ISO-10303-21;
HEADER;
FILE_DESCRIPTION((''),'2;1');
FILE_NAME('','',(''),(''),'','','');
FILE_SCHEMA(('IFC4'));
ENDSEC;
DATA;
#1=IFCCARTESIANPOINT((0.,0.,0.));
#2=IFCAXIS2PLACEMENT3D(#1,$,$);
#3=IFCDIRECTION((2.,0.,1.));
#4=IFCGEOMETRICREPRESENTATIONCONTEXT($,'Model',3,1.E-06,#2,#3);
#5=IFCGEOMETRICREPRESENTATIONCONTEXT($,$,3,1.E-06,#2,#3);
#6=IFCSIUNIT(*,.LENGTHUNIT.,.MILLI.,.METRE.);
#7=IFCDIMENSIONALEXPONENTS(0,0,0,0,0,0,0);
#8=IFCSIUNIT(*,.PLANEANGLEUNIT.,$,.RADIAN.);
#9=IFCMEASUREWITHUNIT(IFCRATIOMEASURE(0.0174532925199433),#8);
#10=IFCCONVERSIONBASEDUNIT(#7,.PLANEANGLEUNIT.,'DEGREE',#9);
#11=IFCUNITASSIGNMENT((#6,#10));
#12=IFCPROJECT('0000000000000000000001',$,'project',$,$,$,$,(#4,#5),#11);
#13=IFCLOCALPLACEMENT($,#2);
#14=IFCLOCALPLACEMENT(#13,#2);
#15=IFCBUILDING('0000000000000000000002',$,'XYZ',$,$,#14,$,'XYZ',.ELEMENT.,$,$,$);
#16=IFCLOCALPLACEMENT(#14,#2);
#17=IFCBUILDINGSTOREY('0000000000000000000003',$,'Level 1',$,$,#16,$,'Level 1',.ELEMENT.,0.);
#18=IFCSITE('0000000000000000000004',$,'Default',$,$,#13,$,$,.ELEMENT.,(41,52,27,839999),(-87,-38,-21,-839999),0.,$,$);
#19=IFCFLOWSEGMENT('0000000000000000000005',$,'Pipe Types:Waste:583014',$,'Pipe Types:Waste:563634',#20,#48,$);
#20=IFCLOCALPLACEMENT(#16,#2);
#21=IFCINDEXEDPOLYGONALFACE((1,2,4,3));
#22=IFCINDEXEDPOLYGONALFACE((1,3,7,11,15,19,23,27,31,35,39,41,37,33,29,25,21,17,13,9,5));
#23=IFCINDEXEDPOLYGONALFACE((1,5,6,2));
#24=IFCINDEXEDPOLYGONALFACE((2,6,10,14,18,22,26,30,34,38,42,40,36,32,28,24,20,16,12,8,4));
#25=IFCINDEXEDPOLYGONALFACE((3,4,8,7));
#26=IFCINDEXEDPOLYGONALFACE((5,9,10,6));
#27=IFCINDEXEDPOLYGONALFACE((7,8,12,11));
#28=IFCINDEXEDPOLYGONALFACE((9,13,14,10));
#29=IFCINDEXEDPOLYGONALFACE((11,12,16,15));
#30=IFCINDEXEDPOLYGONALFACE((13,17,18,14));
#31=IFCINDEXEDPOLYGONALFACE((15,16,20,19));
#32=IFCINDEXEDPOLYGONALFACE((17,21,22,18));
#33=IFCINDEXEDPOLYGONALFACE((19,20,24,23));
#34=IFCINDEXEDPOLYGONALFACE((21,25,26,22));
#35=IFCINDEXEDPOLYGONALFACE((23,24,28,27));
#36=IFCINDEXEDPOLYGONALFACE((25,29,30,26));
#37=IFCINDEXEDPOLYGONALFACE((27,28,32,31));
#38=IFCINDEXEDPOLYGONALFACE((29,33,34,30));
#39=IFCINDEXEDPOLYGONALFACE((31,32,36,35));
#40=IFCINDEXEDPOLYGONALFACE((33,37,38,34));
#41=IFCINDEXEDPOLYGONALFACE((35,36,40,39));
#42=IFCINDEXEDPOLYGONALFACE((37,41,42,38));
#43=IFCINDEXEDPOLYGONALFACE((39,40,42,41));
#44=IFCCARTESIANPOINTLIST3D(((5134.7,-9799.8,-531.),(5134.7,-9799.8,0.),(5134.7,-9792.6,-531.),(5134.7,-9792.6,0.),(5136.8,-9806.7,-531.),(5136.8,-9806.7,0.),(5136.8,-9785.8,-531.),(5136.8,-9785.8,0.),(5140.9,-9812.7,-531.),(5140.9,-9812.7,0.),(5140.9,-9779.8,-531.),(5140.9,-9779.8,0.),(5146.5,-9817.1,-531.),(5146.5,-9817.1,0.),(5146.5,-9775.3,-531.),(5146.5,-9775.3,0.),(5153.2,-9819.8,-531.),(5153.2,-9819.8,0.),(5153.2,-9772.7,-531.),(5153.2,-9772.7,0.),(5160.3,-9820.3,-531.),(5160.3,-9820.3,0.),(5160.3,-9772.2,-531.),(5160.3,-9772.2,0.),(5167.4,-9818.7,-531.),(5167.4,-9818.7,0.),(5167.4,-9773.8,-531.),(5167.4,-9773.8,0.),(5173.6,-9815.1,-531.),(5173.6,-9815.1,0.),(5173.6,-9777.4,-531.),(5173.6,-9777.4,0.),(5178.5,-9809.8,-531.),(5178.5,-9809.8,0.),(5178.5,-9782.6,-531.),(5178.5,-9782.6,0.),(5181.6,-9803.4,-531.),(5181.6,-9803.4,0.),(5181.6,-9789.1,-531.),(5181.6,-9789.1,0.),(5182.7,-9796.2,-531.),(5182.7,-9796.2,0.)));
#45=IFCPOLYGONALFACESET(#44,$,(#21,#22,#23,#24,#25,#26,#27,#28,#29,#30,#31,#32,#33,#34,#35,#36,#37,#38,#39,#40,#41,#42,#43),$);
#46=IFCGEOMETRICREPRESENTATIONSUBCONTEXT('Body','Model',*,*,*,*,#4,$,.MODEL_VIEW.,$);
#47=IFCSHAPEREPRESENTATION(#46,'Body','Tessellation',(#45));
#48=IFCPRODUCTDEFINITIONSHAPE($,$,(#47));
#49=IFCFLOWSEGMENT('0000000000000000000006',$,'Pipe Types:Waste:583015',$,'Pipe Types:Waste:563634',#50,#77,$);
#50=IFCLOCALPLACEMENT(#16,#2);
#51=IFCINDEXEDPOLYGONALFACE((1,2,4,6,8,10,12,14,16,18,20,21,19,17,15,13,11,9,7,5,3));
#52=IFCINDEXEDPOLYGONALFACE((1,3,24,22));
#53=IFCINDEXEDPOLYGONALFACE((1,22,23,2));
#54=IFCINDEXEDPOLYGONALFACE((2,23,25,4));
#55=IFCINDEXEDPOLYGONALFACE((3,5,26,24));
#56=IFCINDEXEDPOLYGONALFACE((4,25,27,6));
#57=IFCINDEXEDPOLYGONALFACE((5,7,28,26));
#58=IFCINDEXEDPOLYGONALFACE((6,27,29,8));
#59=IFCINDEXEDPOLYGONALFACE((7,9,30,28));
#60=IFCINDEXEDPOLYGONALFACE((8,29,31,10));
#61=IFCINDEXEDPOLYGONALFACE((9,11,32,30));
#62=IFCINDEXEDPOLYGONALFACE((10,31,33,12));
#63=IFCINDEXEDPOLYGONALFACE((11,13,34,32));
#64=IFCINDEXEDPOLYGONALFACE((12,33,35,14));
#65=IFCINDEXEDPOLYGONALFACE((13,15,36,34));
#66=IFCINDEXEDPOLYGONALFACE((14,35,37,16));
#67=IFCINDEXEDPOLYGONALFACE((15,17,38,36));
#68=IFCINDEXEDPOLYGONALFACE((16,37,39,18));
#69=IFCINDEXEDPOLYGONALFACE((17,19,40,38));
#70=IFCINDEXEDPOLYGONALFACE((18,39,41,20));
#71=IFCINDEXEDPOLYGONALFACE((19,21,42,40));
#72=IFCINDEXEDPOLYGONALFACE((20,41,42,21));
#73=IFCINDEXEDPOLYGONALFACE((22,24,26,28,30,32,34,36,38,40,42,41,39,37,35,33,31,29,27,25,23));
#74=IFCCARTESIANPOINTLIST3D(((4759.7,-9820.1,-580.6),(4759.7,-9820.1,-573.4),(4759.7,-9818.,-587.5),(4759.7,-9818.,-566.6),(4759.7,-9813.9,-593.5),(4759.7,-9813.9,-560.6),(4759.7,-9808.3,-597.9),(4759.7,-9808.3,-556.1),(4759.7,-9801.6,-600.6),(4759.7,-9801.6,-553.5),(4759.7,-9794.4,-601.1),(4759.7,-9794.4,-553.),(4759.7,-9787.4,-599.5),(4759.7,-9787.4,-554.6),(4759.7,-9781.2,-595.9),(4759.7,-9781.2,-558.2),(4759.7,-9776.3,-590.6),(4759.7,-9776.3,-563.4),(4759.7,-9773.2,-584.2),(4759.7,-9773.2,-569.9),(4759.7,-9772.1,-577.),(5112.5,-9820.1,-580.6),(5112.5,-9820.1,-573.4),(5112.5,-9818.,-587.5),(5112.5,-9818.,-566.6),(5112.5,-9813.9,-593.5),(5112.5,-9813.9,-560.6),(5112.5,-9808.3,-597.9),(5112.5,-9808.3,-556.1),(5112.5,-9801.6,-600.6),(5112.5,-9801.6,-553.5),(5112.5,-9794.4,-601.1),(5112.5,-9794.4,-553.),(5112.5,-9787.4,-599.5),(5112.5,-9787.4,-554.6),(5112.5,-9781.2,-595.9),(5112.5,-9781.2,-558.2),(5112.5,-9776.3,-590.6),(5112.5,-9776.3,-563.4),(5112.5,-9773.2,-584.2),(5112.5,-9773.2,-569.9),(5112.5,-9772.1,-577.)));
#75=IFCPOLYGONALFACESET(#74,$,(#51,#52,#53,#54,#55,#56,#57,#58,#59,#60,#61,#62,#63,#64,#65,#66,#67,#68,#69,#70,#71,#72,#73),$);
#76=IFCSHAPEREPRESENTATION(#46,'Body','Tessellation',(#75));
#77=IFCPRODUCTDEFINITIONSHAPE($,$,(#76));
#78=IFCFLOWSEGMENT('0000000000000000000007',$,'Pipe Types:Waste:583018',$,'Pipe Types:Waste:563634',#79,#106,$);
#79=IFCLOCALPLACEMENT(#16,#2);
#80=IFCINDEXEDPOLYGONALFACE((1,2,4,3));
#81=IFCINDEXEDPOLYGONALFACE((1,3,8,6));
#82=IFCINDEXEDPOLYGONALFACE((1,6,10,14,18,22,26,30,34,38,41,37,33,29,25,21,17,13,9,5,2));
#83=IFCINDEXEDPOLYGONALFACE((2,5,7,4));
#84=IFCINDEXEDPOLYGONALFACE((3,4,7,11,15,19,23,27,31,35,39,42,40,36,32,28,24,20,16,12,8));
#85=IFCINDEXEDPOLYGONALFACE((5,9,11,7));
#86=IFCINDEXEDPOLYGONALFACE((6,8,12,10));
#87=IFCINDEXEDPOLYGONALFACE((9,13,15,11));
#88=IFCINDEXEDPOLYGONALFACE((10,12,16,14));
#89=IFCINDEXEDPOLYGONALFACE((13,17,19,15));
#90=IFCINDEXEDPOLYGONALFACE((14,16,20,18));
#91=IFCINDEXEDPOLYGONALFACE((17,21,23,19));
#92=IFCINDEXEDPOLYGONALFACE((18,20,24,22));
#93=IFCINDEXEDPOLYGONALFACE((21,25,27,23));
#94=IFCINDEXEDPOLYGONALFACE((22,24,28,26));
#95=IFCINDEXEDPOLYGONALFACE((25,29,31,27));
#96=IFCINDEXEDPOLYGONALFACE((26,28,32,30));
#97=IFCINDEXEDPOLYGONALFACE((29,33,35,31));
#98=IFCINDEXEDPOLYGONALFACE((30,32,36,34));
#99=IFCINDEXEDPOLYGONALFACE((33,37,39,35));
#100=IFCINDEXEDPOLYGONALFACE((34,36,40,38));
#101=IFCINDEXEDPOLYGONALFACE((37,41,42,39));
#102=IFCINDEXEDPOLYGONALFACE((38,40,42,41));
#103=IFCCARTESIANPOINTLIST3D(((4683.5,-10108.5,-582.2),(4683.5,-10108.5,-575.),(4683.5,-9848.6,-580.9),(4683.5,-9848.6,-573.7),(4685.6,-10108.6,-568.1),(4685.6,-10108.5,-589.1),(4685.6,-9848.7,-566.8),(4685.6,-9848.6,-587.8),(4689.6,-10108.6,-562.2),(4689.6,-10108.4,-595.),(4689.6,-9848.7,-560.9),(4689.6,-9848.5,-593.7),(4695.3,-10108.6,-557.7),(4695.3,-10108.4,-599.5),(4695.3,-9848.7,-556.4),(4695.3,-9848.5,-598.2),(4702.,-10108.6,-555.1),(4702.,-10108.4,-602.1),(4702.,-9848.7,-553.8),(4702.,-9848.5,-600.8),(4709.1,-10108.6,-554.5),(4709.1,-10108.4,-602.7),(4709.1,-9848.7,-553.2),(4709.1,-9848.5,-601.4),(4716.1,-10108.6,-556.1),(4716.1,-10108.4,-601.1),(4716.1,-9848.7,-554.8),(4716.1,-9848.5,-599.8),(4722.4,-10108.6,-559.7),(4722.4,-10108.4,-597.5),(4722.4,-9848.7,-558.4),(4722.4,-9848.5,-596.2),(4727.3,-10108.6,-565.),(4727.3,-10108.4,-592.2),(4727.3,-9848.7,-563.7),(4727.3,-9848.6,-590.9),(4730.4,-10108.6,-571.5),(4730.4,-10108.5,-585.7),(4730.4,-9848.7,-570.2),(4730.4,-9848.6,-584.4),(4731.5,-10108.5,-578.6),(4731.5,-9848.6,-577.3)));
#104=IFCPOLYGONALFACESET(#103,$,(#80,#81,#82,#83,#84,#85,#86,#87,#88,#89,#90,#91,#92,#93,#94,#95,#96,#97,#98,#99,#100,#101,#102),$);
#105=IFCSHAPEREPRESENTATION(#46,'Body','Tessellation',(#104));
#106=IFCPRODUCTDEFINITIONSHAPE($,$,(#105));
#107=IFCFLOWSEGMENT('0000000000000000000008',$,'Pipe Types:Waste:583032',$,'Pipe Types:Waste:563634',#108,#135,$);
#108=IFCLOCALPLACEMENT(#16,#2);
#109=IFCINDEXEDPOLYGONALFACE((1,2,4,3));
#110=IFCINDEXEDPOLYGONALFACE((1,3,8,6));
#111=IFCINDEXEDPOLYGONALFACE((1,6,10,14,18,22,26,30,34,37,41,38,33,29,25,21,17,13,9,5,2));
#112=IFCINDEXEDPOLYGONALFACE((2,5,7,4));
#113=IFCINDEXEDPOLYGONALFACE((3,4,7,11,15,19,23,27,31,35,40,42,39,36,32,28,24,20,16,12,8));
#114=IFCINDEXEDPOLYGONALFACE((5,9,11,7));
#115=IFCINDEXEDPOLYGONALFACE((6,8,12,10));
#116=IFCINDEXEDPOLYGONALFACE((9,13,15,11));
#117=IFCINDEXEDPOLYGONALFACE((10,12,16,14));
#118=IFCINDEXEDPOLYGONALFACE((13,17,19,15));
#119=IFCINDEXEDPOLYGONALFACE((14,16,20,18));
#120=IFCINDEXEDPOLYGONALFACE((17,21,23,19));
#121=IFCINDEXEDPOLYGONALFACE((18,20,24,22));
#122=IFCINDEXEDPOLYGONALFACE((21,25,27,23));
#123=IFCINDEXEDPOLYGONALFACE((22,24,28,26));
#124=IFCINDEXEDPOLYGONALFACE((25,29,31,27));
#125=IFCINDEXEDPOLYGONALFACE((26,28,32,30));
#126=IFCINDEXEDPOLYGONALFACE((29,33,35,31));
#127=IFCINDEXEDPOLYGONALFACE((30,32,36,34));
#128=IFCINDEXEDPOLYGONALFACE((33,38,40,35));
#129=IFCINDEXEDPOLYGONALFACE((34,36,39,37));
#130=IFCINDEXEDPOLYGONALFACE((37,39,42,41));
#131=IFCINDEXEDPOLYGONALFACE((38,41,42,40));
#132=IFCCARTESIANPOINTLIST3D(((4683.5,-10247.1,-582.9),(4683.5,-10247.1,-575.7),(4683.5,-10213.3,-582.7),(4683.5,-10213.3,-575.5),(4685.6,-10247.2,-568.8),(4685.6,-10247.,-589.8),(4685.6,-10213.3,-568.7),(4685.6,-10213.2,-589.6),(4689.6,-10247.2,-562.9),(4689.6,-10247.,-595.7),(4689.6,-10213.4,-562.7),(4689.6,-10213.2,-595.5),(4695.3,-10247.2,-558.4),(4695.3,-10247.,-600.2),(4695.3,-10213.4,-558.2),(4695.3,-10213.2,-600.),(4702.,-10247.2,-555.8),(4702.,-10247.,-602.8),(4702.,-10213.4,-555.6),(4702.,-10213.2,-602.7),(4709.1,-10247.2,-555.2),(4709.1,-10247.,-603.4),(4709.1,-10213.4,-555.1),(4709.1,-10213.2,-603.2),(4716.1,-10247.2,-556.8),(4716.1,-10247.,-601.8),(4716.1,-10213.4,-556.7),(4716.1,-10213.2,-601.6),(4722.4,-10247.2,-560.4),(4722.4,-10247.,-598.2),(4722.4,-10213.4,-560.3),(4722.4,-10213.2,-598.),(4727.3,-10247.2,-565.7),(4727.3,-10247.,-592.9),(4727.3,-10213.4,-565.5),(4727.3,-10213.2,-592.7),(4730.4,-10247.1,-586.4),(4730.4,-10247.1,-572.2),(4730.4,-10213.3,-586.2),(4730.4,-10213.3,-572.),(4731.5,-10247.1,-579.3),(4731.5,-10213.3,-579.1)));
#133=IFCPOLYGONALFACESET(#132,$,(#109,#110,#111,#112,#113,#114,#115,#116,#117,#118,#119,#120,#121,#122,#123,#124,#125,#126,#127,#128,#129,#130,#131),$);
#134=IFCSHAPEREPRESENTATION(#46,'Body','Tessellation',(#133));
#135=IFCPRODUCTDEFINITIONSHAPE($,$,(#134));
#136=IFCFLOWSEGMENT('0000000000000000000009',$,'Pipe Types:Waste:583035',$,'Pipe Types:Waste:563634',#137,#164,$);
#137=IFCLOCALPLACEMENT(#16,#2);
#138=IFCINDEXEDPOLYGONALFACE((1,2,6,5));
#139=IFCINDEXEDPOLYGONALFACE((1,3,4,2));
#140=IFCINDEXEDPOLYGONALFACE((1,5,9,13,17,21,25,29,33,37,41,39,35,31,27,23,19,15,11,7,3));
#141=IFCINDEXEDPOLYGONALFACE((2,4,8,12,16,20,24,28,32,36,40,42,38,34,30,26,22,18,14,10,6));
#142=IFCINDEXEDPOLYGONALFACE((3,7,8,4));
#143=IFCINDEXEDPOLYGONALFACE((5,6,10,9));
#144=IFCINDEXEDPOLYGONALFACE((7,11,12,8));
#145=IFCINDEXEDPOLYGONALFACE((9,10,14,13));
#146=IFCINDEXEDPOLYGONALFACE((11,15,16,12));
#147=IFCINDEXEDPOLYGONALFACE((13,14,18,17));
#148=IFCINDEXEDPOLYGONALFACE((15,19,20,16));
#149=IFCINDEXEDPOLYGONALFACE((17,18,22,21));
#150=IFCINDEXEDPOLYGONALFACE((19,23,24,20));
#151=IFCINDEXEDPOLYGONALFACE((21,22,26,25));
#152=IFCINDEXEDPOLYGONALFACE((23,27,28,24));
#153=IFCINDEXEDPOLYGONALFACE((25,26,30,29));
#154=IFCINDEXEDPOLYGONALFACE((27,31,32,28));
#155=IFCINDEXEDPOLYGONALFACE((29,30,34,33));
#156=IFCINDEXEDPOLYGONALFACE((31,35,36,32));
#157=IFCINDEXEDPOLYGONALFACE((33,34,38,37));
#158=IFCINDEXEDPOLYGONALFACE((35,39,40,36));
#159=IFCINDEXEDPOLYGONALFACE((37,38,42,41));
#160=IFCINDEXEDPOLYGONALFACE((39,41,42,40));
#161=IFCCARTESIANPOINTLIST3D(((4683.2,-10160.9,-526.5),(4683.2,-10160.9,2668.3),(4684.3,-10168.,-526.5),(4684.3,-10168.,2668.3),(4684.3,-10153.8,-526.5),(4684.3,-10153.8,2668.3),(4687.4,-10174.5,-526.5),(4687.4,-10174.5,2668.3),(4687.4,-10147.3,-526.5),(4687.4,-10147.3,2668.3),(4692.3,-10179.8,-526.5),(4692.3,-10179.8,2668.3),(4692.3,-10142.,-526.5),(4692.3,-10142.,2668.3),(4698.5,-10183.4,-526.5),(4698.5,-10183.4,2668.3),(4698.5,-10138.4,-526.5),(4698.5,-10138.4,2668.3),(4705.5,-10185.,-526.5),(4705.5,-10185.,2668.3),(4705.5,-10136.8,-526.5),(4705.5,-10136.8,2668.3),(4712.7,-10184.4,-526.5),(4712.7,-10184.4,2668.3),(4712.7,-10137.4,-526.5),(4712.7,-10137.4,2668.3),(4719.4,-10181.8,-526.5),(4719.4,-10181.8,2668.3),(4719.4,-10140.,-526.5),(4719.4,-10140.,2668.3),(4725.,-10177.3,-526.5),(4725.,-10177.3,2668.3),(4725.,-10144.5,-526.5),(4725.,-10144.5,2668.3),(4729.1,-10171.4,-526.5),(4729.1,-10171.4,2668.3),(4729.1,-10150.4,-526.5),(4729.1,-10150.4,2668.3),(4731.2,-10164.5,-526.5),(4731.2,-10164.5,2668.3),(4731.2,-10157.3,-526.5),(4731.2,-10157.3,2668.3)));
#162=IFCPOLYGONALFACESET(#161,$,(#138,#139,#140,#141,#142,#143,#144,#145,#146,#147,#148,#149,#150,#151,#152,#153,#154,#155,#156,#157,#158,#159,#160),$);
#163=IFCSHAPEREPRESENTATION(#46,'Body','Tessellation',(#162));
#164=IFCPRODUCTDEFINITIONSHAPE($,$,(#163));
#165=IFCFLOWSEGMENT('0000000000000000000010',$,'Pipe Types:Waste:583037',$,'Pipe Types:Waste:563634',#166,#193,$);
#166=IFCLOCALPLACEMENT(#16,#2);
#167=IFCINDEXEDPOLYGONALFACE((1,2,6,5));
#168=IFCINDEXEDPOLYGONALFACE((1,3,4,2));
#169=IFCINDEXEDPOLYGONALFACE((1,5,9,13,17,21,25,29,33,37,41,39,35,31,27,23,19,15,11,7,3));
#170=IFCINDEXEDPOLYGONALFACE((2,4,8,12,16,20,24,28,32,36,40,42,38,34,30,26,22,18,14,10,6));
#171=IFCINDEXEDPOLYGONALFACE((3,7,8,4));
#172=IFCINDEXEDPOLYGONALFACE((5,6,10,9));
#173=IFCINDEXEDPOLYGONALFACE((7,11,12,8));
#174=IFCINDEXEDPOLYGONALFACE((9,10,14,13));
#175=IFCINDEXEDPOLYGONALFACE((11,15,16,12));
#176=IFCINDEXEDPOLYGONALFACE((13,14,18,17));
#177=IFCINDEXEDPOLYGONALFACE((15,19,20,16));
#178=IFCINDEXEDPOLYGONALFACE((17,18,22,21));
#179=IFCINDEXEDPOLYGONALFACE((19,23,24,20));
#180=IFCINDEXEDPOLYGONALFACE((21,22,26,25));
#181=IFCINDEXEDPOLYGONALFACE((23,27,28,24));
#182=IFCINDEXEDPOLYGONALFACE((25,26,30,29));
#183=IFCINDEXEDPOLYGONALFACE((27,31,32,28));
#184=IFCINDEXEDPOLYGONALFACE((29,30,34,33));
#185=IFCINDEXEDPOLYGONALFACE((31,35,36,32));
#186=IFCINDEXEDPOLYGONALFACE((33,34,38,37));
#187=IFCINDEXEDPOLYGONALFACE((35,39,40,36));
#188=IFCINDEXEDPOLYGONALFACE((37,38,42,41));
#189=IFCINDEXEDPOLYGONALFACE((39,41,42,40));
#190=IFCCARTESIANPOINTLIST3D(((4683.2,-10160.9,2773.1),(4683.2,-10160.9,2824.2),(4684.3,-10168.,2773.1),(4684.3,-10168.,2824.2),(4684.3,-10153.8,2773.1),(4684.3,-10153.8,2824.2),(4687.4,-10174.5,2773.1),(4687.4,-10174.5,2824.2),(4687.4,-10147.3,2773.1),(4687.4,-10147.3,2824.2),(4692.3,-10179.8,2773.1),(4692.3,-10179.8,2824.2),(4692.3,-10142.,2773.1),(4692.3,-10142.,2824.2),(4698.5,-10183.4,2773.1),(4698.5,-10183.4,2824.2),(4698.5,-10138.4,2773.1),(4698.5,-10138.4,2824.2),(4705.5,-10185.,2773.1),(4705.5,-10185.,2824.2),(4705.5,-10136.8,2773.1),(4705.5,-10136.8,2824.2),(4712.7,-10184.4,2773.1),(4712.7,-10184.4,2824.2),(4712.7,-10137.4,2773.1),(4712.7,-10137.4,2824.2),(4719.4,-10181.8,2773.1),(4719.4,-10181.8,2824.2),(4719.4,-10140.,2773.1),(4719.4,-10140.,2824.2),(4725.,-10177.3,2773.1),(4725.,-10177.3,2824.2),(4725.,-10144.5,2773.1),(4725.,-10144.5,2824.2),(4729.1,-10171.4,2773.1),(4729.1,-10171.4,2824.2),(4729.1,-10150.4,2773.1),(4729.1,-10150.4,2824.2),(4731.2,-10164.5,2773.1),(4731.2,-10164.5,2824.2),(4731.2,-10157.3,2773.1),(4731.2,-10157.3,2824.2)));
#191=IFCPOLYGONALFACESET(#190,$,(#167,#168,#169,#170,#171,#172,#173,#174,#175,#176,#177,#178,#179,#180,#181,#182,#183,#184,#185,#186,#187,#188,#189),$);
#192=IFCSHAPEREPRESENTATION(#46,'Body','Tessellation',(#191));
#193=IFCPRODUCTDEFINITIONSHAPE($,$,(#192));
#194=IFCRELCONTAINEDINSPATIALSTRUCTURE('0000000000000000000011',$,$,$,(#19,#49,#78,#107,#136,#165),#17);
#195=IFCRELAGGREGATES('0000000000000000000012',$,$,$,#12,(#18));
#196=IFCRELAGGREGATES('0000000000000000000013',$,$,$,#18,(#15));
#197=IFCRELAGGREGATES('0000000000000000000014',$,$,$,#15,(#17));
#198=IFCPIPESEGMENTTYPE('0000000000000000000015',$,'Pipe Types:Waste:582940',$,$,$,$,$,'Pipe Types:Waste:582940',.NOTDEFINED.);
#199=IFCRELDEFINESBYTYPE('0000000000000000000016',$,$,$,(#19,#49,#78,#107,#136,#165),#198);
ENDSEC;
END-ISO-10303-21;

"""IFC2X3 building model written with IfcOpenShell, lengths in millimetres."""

from ifc_helpers import new_model, entity, si_unit, converted_unit, direction, frame, frame_2d, origin, origin_2d_with_axis, place, context, subcontext, project, spatial, circle, extrude, type_object, element, save


model = new_model("IFC2X3")

# Units and contexts
model_context = context("Model", 3, precision=1e-06, world=origin(), true_north=direction((2.0, 0.0, 1.0)))
context_of_model = context(None, 3, precision=1e-06, world=origin(), true_north=direction((2.0, 0.0, 1.0)))
body_context = subcontext(model_context, "Body", "Model", "MODEL_VIEW")
ifc_project = project(units=[si_unit("LENGTHUNIT", "METRE", prefix="MILLI"), converted_unit("PLANEANGLEUNIT", "DEGREE", entity("IfcRatioMeasure", 0.0174532925199433), si_unit("PLANEANGLEUNIT", "RADIAN"), dimensions=[0, 0, 0, 0, 0, 0, 0])], contexts=[model_context, context_of_model])

# Site, building, storey
site_placement = place(None, origin())
site = spatial("IfcSite", under=ifc_project, at=site_placement, Name="Default", CompositionType="ELEMENT", RefLatitude=(41, 52, 27, 839999), RefLongitude=(-87, -38, -21, -839999), RefElevation=0.0)
building_placement = place(site_placement, origin())
building = spatial("IfcBuilding", under=site, at=building_placement, Name="XYZ", LongName="XYZ", CompositionType="ELEMENT")
storey_placement = place(building_placement, origin())
storey = spatial("IfcBuildingStorey", under=building, at=storey_placement, Name="Level 1", LongName="Level 1", CompositionType="ELEMENT", Elevation=0.0)

# Flow segments
pipe_segment_type_1 = type_object("IfcPipeSegmentType", Name="Pipe Types:Waste:582940", ElementType="Pipe Types:Waste:582940", PredefinedType="NOTDEFINED")
flow_segment_1_placement = place(storey_placement, origin())
element("IfcFlowSegment", 1, at=flow_segment_1_placement, inside=storey, type_object=pipe_segment_type_1, Name="Pipe Types:Waste:583014", ObjectType="Pipe Types:Waste:563634", context=body_context, shape_type="SweptSolid", body=[
    extrude(circle(Radius=24.1, at=origin_2d_with_axis()), frame((5158.5, -9796.2, -531.0)), (0.0, 0.0, 1.0), 531.0),
])
flow_segment_2_placement = place(storey_placement, origin())
element("IfcFlowSegment", 2, at=flow_segment_2_placement, inside=storey, type_object=pipe_segment_type_1, Name="Pipe Types:Waste:583015", ObjectType="Pipe Types:Waste:563634", context=body_context, shape_type="SweptSolid", body=[
    extrude(circle(Radius=24.1, at=origin_2d_with_axis()), frame((4759.7, -9796.2, -577.0), z_axis=(1.0, 0.0, 0.0), x_axis=(0.0, 1.0, 0.0)), (0.0, 0.0, 1.0), 352.8),
])
flow_segment_3_placement = place(storey_placement, origin())
element("IfcFlowSegment", 3, at=flow_segment_3_placement, inside=storey, type_object=pipe_segment_type_1, Name="Pipe Types:Waste:583018", ObjectType="Pipe Types:Waste:563634", context=body_context, shape_type="SweptSolid", body=[
    extrude(circle(Radius=24.1, at=origin_2d_with_axis()), frame((4707.3, -10108.5, -578.6), z_axis=(0.0, 0.999988, 0.005), x_axis=(1.0, 0.0, 0.0)), (0.0, 0.0, 1.0), 259.9),
])
flow_segment_4_placement = place(storey_placement, origin())
element("IfcFlowSegment", 4, at=flow_segment_4_placement, inside=storey, type_object=pipe_segment_type_1, Name="Pipe Types:Waste:583032", ObjectType="Pipe Types:Waste:563634", context=body_context, shape_type="SweptSolid", body=[
    extrude(circle(Radius=24.1, at=frame_2d((0.0, 0.0), x_axis=(1.0, 0.0))), frame((4707.3, -10247.1, -579.3), z_axis=(0.0, 0.999988, 0.005), x_axis=(1.0, 0.0, 0.0)), (0.0, 0.0, 1.0), 33.8),
])
flow_segment_5_placement = place(storey_placement, origin())
element("IfcFlowSegment", 5, at=flow_segment_5_placement, inside=storey, type_object=pipe_segment_type_1, Name="Pipe Types:Waste:583035", ObjectType="Pipe Types:Waste:563634", context=body_context, shape_type="SweptSolid", body=[
    extrude(circle(Radius=24.1, at=frame_2d((0.0, 0.0), x_axis=(1.0, 0.0))), frame((4707.3, -10160.9, -526.5), z_axis=(0.0, 0.000001, 1.0), x_axis=(-1.0, 0.0, 0.0)), (0.0, 0.0, 1.0), 3194.8),
])
flow_segment_6_placement = place(storey_placement, origin())
element("IfcFlowSegment", 6, at=flow_segment_6_placement, inside=storey, type_object=pipe_segment_type_1, Name="Pipe Types:Waste:583037", ObjectType="Pipe Types:Waste:563634", context=body_context, shape_type="SweptSolid", body=[
    extrude(circle(Radius=24.1, at=frame_2d((0.0, 0.0), x_axis=(1.0, 0.0))), frame((4707.3, -10160.9, 2773.1), z_axis=(0.0, -0.000038, 1.0), x_axis=(-1.0, 0.0, 0.0)), (0.0, 0.0, 1.0), 51.1),
])

save(model, "model.ifc")
